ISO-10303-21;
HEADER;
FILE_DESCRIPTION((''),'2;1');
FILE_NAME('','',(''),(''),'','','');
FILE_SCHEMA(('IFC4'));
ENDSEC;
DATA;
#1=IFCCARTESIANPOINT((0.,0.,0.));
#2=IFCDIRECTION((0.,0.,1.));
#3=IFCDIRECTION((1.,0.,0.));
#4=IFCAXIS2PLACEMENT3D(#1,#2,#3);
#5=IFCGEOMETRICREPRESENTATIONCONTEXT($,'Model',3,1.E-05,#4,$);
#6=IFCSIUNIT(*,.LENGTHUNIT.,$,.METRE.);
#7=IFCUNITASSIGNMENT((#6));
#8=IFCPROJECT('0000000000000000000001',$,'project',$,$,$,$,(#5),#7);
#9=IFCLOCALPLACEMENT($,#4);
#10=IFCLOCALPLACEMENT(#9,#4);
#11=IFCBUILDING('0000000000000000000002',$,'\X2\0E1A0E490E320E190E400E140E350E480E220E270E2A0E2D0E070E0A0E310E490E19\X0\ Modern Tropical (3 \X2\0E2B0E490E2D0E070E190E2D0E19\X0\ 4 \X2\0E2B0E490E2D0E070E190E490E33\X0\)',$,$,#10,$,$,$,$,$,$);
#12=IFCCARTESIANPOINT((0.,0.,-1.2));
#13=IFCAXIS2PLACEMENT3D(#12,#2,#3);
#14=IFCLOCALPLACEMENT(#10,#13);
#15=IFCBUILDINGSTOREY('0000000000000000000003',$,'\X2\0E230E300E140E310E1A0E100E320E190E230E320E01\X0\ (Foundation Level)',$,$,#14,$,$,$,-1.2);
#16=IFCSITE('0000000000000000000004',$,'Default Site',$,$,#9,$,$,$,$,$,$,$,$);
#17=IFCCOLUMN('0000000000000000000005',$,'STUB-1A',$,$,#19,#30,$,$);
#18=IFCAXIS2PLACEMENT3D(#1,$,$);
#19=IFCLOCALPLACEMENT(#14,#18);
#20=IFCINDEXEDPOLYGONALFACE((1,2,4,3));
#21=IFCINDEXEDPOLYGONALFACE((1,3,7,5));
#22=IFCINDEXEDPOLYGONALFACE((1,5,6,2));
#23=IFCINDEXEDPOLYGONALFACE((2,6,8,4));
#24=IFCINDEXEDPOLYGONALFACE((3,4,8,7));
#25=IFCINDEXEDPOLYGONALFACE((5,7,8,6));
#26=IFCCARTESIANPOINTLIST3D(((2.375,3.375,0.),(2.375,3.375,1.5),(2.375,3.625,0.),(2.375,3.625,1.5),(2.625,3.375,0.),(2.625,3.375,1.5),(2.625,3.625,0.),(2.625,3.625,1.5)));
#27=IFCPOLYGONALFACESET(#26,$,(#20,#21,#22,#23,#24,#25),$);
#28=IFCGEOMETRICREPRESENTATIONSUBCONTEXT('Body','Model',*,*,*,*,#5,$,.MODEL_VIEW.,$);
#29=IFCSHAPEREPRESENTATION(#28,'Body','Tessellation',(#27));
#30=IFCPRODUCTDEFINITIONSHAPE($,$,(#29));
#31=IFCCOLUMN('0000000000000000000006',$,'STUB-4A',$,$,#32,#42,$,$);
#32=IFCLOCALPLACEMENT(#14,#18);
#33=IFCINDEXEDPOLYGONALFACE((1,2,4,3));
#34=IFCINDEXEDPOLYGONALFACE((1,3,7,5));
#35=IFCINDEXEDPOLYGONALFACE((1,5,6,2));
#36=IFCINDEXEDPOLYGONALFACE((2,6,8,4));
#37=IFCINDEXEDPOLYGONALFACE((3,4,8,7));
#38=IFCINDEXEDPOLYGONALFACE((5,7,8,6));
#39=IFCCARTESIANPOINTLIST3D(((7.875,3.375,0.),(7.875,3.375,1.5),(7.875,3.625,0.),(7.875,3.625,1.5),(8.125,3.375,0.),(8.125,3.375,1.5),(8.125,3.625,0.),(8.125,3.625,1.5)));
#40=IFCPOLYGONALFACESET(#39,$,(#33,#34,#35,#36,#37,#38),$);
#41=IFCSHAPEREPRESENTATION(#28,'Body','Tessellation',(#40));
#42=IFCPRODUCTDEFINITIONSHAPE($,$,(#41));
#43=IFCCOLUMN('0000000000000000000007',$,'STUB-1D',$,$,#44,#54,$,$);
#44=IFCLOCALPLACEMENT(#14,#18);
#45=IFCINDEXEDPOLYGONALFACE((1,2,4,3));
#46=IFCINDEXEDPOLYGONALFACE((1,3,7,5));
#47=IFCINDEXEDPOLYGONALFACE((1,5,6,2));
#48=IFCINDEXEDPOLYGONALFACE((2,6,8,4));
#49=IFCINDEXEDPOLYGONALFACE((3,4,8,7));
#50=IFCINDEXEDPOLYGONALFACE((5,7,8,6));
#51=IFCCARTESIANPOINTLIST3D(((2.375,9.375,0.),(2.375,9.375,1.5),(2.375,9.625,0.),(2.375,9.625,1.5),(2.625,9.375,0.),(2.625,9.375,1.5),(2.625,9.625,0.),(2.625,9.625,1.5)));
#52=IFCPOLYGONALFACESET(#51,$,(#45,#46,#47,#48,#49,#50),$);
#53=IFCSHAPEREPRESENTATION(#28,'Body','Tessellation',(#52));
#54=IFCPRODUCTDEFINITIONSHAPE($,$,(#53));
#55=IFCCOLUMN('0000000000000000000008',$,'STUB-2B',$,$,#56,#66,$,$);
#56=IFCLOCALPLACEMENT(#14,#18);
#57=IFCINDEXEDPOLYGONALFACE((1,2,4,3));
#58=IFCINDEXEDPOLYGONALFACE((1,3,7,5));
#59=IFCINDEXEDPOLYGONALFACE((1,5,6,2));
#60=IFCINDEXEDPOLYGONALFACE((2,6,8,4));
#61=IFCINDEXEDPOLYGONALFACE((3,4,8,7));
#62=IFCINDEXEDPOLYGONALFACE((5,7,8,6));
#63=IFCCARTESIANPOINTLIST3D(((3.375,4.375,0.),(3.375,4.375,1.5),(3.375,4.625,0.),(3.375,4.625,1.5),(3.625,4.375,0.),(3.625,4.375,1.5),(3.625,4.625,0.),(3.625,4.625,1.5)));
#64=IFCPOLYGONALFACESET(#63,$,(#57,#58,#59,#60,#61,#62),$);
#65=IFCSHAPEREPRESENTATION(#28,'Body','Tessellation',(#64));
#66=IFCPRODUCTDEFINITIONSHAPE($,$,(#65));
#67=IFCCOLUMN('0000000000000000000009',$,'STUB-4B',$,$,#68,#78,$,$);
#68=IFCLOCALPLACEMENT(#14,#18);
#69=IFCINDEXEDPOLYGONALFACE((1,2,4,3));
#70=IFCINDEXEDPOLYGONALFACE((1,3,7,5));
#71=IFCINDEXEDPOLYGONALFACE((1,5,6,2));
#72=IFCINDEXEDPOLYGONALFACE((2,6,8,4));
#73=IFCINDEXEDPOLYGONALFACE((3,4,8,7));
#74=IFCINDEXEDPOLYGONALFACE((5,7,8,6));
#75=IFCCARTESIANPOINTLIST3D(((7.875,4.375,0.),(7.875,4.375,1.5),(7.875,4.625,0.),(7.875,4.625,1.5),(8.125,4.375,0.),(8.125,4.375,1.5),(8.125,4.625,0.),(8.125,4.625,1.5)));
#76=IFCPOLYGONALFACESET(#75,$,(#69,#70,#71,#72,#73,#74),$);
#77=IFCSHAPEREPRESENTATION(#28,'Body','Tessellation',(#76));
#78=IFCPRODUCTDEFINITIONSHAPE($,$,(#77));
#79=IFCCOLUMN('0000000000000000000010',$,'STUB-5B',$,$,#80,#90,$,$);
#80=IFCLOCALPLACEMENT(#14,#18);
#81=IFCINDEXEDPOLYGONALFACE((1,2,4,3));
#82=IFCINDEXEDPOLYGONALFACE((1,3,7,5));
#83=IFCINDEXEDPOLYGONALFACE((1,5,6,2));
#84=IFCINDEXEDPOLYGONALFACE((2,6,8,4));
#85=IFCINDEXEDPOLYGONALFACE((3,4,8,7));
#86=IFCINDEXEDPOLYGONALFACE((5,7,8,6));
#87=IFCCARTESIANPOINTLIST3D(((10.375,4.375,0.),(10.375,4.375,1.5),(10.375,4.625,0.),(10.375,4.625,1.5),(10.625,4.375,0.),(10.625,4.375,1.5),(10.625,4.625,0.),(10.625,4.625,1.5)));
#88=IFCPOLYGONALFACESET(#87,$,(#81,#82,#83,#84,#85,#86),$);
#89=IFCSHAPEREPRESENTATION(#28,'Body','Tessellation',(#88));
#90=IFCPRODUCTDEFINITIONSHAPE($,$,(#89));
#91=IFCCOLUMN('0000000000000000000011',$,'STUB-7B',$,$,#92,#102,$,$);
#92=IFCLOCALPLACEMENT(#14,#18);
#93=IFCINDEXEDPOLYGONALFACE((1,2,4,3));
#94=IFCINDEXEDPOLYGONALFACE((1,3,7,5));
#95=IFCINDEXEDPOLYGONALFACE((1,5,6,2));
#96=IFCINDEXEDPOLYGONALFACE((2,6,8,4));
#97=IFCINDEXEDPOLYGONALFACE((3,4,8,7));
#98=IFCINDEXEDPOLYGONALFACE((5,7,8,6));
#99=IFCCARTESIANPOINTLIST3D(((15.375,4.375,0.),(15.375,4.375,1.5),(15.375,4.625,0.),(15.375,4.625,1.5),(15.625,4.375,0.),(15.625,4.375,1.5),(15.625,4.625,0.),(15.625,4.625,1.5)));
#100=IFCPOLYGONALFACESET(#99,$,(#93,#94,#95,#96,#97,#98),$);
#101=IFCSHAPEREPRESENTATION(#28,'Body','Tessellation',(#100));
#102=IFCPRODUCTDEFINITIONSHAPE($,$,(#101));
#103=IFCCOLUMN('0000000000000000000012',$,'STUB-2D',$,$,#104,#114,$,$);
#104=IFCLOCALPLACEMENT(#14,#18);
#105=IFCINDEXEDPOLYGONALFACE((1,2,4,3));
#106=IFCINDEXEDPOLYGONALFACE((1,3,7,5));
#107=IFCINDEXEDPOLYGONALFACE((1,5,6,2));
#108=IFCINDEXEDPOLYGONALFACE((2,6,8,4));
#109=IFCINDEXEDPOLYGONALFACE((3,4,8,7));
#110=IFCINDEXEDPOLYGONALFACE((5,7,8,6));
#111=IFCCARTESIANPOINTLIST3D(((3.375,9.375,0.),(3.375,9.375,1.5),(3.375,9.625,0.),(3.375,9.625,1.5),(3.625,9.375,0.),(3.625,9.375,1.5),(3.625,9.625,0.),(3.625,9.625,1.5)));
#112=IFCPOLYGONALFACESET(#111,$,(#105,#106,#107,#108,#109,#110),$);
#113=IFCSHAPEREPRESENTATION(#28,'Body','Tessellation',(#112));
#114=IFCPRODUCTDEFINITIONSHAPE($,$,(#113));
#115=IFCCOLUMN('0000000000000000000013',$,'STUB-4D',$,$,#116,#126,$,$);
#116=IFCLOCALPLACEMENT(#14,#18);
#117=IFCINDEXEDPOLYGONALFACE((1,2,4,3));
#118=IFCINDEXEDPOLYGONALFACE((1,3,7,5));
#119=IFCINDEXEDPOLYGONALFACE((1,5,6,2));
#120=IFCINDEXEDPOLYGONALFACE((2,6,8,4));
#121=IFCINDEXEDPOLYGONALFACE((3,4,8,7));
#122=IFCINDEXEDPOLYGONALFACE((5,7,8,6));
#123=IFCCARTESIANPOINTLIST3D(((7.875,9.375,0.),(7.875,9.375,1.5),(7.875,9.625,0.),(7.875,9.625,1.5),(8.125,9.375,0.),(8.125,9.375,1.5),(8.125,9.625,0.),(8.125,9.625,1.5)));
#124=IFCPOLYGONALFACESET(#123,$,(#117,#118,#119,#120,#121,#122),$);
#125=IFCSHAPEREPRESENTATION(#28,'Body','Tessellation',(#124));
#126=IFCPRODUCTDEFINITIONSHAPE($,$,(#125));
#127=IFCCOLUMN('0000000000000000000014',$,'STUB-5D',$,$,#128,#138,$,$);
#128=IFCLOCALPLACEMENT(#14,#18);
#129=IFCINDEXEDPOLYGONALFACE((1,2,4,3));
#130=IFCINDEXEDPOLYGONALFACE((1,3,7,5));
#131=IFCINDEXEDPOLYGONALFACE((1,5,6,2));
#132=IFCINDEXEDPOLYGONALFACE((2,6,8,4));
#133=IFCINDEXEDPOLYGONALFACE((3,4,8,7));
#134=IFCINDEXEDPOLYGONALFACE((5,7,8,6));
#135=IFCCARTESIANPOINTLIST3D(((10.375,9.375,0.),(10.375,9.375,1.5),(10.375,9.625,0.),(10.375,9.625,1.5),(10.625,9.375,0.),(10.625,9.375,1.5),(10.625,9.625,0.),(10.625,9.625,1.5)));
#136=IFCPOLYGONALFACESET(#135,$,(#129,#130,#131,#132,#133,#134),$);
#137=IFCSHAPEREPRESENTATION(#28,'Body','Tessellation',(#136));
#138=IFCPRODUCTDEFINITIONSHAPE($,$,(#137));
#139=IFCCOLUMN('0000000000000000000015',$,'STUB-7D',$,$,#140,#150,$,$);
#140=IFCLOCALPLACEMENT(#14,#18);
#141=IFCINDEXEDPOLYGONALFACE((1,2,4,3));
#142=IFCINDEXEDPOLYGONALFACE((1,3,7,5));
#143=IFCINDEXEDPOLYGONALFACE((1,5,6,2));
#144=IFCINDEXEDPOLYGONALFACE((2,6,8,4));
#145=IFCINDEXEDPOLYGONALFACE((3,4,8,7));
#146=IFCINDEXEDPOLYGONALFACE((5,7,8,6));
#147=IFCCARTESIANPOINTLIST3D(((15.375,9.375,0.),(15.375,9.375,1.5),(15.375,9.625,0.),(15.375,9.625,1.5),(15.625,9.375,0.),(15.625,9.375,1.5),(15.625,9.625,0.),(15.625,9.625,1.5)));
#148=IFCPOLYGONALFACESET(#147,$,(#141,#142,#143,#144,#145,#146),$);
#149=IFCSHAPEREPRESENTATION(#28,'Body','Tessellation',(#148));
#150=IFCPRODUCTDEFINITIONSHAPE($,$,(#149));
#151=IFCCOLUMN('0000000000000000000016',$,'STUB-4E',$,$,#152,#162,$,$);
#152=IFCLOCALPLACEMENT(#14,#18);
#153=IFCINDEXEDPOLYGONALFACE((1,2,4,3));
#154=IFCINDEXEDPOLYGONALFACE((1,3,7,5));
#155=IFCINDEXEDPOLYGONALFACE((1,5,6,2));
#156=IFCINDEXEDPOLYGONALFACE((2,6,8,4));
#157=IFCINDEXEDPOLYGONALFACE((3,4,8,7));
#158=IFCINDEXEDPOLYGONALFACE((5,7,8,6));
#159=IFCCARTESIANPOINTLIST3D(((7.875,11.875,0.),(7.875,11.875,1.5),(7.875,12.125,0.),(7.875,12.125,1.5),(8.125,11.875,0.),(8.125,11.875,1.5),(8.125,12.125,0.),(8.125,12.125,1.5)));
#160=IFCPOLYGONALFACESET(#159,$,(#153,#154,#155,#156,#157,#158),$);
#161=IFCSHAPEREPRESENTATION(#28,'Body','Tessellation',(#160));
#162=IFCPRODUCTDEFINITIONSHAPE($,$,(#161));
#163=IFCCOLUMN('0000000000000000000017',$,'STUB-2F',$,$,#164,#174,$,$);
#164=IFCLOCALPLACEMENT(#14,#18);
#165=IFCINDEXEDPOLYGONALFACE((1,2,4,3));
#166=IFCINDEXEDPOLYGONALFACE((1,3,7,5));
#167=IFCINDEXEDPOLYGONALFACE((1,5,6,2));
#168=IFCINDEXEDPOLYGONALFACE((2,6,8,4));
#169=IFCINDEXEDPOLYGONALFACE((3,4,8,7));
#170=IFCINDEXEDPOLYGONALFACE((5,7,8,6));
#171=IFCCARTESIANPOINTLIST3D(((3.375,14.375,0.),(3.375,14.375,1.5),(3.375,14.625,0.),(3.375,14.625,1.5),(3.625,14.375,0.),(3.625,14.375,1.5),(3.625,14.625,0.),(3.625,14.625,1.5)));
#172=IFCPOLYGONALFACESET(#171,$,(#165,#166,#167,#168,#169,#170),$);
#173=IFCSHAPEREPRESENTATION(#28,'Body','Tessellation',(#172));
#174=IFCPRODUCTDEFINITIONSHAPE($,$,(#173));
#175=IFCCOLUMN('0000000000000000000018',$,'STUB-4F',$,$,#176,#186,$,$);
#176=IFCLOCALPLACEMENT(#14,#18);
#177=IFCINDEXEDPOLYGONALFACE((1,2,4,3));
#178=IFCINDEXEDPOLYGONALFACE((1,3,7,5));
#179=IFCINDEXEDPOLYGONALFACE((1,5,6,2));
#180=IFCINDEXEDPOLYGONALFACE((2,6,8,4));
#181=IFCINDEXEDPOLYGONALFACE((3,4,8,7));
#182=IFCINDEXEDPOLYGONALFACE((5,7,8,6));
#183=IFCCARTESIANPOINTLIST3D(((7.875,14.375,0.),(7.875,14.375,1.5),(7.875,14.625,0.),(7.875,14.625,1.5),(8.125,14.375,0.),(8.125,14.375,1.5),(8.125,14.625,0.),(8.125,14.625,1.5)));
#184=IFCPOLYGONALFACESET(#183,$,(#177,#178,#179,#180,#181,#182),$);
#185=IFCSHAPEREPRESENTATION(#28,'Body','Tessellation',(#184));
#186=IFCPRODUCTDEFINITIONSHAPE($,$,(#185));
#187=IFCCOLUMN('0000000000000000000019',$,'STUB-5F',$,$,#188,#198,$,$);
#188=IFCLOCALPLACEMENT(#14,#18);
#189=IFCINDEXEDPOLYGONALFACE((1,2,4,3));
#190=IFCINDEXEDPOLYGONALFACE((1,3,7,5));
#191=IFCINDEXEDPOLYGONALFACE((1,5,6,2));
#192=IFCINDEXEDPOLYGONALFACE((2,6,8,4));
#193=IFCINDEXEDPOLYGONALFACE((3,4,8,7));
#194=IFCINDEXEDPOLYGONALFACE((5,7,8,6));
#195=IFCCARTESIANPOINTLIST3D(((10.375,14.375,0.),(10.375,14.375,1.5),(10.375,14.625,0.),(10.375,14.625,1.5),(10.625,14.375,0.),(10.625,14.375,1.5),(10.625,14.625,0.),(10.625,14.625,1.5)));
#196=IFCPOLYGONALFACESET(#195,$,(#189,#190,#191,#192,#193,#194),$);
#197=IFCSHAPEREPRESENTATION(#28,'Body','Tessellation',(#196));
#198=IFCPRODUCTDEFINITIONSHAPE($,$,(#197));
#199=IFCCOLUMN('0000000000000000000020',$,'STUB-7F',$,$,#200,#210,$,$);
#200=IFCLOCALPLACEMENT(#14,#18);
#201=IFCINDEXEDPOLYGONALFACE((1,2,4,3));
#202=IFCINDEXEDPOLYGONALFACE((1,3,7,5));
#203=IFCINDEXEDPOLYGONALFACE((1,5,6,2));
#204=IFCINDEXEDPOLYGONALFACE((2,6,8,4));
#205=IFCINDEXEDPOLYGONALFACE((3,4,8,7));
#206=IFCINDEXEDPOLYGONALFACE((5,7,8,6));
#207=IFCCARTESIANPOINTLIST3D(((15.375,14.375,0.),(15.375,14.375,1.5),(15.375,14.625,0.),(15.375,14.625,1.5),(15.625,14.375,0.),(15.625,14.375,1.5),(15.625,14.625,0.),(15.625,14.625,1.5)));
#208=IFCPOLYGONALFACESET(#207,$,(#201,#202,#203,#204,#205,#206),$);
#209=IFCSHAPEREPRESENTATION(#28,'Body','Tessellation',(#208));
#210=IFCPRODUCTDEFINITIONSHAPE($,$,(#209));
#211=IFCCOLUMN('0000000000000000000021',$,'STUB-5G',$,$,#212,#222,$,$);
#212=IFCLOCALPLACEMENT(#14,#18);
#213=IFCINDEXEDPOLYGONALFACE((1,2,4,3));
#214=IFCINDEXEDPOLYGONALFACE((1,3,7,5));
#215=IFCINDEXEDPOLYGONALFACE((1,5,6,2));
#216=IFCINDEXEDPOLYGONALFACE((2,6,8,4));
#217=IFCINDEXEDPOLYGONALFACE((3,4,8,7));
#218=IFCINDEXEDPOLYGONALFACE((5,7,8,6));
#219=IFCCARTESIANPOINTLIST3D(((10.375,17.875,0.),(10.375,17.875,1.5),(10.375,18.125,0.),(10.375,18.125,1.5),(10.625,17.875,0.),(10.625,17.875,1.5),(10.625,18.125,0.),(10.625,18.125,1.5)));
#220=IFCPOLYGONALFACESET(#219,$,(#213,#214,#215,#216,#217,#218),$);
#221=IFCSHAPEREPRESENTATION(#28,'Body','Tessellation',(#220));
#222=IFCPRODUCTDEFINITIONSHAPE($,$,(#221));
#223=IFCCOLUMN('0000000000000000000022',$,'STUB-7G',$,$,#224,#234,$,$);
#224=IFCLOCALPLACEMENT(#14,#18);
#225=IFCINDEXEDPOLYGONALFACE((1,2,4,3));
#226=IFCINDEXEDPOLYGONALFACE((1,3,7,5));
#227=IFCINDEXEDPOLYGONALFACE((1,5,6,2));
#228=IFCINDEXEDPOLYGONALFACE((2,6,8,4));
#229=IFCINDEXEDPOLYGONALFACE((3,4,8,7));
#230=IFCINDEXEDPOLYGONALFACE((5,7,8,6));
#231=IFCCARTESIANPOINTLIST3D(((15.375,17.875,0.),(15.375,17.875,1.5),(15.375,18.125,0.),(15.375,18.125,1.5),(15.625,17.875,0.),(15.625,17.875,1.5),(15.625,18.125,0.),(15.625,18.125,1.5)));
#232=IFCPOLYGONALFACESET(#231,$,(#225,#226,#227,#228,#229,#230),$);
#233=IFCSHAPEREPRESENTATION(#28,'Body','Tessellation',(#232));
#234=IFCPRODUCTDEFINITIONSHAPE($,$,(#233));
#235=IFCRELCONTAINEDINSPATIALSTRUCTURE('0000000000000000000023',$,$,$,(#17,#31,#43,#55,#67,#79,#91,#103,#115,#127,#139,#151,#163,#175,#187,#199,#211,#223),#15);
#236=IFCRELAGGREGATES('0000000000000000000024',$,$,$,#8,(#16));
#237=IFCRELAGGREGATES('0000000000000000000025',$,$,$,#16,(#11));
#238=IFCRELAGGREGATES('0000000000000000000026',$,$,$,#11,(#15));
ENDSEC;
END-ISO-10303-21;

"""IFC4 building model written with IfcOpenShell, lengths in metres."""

from ifc_helpers import new_model, si_unit, frame, origin_with_axes, origin_2d, place, context, subcontext, project, spatial, rectangle, extrude, element, save


model = new_model("IFC4")

# Units and contexts
model_context = context("Model", 3, precision=1e-05, world=origin_with_axes())
body_context = subcontext(model_context, "Body", "Model", "MODEL_VIEW")
ifc_project = project(units=[si_unit("LENGTHUNIT", "METRE")], contexts=[model_context])

# Site, building, storey
site_placement = place(None, origin_with_axes())
site = spatial("IfcSite", under=ifc_project, at=site_placement, Name="Default Site")
building_placement = place(site_placement, origin_with_axes())
building = spatial("IfcBuilding", under=site, at=building_placement, Name="บ้านเดี่ยวสองชั้น Modern Tropical (3 ห้องนอน 4 ห้องน้ำ)")
storey_placement = place(building_placement, frame((0.0, 0.0, -1.2), z_axis=(0.0, 0.0, 1.0), x_axis=(1.0, 0.0, 0.0)))
storey = spatial("IfcBuildingStorey", under=building, at=storey_placement, Name="ระดับฐานราก (Foundation Level)", Elevation=-1.2)

# Columns
for number, where, z_axis, x_axis, name in (
    (1, (2.5, 3.5, 0.0), (0.0, 0.0, 1.0), (1.0, 0.0, 0.0), "STUB-1A"),
    (2, (8.0, 3.5, 0.0), (0.0, 0.0, 1.0), (1.0, 0.0, 0.0), "STUB-4A"),
    (3, (2.5, 9.5, 0.0), (0.0, 0.0, 1.0), (1.0, 0.0, 0.0), "STUB-1D"),
    (4, (3.5, 4.5, 0.0), (0.0, 0.0, 1.0), (1.0, 0.0, 0.0), "STUB-2B"),
    (5, (8.0, 4.5, 0.0), (0.0, 0.0, 1.0), (1.0, 0.0, 0.0), "STUB-4B"),
    (6, (10.5, 4.5, 0.0), (0.0, 0.0, 1.0), (1.0, 0.0, 0.0), "STUB-5B"),
    (7, (15.5, 4.5, 0.0), (0.0, 0.0, 1.0), (1.0, 0.0, 0.0), "STUB-7B"),
    (8, (3.5, 9.5, 0.0), (0.0, 0.0, 1.0), (1.0, 0.0, 0.0), "STUB-2D"),
    (9, (8.0, 9.5, 0.0), (0.0, 0.0, 1.0), (1.0, 0.0, 0.0), "STUB-4D"),
    (10, (10.5, 9.5, 0.0), (0.0, 0.0, 1.0), (1.0, 0.0, 0.0), "STUB-5D"),
    (11, (15.5, 9.5, 0.0), (0.0, 0.0, 1.0), (1.0, 0.0, 0.0), "STUB-7D"),
    (12, (8.0, 12.0, 0.0), (0.0, 0.0, 1.0), (1.0, 0.0, 0.0), "STUB-4E"),
    (13, (3.5, 14.5, 0.0), (0.0, 0.0, 1.0), (1.0, 0.0, 0.0), "STUB-2F"),
    (14, (8.0, 14.5, 0.0), (0.0, 0.0, 1.0), (1.0, 0.0, 0.0), "STUB-4F"),
    (15, (10.5, 14.5, 0.0), (0.0, 0.0, 1.0), (1.0, 0.0, 0.0), "STUB-5F"),
    (16, (15.5, 14.5, 0.0), (0.0, 0.0, 1.0), (1.0, 0.0, 0.0), "STUB-7F"),
    (17, (10.5, 18.0, 0.0), (0.0, 0.0, 1.0), (1.0, 0.0, 0.0), "STUB-5G"),
    (18, (15.5, 18.0, 0.0), (0.0, 0.0, 1.0), (1.0, 0.0, 0.0), "STUB-7G"),
):
    element("IfcColumn", number, at=place(storey_placement, frame(where, z_axis=z_axis, x_axis=x_axis)), inside=storey, Name=name, context=body_context, shape_type="SweptSolid", body=[
        extrude(rectangle(XDim=0.25, YDim=0.25, at=origin_2d()), origin_with_axes(), (0.0, 0.0, 1.0), 1.5),
    ])

save(model, "model.ifc")
